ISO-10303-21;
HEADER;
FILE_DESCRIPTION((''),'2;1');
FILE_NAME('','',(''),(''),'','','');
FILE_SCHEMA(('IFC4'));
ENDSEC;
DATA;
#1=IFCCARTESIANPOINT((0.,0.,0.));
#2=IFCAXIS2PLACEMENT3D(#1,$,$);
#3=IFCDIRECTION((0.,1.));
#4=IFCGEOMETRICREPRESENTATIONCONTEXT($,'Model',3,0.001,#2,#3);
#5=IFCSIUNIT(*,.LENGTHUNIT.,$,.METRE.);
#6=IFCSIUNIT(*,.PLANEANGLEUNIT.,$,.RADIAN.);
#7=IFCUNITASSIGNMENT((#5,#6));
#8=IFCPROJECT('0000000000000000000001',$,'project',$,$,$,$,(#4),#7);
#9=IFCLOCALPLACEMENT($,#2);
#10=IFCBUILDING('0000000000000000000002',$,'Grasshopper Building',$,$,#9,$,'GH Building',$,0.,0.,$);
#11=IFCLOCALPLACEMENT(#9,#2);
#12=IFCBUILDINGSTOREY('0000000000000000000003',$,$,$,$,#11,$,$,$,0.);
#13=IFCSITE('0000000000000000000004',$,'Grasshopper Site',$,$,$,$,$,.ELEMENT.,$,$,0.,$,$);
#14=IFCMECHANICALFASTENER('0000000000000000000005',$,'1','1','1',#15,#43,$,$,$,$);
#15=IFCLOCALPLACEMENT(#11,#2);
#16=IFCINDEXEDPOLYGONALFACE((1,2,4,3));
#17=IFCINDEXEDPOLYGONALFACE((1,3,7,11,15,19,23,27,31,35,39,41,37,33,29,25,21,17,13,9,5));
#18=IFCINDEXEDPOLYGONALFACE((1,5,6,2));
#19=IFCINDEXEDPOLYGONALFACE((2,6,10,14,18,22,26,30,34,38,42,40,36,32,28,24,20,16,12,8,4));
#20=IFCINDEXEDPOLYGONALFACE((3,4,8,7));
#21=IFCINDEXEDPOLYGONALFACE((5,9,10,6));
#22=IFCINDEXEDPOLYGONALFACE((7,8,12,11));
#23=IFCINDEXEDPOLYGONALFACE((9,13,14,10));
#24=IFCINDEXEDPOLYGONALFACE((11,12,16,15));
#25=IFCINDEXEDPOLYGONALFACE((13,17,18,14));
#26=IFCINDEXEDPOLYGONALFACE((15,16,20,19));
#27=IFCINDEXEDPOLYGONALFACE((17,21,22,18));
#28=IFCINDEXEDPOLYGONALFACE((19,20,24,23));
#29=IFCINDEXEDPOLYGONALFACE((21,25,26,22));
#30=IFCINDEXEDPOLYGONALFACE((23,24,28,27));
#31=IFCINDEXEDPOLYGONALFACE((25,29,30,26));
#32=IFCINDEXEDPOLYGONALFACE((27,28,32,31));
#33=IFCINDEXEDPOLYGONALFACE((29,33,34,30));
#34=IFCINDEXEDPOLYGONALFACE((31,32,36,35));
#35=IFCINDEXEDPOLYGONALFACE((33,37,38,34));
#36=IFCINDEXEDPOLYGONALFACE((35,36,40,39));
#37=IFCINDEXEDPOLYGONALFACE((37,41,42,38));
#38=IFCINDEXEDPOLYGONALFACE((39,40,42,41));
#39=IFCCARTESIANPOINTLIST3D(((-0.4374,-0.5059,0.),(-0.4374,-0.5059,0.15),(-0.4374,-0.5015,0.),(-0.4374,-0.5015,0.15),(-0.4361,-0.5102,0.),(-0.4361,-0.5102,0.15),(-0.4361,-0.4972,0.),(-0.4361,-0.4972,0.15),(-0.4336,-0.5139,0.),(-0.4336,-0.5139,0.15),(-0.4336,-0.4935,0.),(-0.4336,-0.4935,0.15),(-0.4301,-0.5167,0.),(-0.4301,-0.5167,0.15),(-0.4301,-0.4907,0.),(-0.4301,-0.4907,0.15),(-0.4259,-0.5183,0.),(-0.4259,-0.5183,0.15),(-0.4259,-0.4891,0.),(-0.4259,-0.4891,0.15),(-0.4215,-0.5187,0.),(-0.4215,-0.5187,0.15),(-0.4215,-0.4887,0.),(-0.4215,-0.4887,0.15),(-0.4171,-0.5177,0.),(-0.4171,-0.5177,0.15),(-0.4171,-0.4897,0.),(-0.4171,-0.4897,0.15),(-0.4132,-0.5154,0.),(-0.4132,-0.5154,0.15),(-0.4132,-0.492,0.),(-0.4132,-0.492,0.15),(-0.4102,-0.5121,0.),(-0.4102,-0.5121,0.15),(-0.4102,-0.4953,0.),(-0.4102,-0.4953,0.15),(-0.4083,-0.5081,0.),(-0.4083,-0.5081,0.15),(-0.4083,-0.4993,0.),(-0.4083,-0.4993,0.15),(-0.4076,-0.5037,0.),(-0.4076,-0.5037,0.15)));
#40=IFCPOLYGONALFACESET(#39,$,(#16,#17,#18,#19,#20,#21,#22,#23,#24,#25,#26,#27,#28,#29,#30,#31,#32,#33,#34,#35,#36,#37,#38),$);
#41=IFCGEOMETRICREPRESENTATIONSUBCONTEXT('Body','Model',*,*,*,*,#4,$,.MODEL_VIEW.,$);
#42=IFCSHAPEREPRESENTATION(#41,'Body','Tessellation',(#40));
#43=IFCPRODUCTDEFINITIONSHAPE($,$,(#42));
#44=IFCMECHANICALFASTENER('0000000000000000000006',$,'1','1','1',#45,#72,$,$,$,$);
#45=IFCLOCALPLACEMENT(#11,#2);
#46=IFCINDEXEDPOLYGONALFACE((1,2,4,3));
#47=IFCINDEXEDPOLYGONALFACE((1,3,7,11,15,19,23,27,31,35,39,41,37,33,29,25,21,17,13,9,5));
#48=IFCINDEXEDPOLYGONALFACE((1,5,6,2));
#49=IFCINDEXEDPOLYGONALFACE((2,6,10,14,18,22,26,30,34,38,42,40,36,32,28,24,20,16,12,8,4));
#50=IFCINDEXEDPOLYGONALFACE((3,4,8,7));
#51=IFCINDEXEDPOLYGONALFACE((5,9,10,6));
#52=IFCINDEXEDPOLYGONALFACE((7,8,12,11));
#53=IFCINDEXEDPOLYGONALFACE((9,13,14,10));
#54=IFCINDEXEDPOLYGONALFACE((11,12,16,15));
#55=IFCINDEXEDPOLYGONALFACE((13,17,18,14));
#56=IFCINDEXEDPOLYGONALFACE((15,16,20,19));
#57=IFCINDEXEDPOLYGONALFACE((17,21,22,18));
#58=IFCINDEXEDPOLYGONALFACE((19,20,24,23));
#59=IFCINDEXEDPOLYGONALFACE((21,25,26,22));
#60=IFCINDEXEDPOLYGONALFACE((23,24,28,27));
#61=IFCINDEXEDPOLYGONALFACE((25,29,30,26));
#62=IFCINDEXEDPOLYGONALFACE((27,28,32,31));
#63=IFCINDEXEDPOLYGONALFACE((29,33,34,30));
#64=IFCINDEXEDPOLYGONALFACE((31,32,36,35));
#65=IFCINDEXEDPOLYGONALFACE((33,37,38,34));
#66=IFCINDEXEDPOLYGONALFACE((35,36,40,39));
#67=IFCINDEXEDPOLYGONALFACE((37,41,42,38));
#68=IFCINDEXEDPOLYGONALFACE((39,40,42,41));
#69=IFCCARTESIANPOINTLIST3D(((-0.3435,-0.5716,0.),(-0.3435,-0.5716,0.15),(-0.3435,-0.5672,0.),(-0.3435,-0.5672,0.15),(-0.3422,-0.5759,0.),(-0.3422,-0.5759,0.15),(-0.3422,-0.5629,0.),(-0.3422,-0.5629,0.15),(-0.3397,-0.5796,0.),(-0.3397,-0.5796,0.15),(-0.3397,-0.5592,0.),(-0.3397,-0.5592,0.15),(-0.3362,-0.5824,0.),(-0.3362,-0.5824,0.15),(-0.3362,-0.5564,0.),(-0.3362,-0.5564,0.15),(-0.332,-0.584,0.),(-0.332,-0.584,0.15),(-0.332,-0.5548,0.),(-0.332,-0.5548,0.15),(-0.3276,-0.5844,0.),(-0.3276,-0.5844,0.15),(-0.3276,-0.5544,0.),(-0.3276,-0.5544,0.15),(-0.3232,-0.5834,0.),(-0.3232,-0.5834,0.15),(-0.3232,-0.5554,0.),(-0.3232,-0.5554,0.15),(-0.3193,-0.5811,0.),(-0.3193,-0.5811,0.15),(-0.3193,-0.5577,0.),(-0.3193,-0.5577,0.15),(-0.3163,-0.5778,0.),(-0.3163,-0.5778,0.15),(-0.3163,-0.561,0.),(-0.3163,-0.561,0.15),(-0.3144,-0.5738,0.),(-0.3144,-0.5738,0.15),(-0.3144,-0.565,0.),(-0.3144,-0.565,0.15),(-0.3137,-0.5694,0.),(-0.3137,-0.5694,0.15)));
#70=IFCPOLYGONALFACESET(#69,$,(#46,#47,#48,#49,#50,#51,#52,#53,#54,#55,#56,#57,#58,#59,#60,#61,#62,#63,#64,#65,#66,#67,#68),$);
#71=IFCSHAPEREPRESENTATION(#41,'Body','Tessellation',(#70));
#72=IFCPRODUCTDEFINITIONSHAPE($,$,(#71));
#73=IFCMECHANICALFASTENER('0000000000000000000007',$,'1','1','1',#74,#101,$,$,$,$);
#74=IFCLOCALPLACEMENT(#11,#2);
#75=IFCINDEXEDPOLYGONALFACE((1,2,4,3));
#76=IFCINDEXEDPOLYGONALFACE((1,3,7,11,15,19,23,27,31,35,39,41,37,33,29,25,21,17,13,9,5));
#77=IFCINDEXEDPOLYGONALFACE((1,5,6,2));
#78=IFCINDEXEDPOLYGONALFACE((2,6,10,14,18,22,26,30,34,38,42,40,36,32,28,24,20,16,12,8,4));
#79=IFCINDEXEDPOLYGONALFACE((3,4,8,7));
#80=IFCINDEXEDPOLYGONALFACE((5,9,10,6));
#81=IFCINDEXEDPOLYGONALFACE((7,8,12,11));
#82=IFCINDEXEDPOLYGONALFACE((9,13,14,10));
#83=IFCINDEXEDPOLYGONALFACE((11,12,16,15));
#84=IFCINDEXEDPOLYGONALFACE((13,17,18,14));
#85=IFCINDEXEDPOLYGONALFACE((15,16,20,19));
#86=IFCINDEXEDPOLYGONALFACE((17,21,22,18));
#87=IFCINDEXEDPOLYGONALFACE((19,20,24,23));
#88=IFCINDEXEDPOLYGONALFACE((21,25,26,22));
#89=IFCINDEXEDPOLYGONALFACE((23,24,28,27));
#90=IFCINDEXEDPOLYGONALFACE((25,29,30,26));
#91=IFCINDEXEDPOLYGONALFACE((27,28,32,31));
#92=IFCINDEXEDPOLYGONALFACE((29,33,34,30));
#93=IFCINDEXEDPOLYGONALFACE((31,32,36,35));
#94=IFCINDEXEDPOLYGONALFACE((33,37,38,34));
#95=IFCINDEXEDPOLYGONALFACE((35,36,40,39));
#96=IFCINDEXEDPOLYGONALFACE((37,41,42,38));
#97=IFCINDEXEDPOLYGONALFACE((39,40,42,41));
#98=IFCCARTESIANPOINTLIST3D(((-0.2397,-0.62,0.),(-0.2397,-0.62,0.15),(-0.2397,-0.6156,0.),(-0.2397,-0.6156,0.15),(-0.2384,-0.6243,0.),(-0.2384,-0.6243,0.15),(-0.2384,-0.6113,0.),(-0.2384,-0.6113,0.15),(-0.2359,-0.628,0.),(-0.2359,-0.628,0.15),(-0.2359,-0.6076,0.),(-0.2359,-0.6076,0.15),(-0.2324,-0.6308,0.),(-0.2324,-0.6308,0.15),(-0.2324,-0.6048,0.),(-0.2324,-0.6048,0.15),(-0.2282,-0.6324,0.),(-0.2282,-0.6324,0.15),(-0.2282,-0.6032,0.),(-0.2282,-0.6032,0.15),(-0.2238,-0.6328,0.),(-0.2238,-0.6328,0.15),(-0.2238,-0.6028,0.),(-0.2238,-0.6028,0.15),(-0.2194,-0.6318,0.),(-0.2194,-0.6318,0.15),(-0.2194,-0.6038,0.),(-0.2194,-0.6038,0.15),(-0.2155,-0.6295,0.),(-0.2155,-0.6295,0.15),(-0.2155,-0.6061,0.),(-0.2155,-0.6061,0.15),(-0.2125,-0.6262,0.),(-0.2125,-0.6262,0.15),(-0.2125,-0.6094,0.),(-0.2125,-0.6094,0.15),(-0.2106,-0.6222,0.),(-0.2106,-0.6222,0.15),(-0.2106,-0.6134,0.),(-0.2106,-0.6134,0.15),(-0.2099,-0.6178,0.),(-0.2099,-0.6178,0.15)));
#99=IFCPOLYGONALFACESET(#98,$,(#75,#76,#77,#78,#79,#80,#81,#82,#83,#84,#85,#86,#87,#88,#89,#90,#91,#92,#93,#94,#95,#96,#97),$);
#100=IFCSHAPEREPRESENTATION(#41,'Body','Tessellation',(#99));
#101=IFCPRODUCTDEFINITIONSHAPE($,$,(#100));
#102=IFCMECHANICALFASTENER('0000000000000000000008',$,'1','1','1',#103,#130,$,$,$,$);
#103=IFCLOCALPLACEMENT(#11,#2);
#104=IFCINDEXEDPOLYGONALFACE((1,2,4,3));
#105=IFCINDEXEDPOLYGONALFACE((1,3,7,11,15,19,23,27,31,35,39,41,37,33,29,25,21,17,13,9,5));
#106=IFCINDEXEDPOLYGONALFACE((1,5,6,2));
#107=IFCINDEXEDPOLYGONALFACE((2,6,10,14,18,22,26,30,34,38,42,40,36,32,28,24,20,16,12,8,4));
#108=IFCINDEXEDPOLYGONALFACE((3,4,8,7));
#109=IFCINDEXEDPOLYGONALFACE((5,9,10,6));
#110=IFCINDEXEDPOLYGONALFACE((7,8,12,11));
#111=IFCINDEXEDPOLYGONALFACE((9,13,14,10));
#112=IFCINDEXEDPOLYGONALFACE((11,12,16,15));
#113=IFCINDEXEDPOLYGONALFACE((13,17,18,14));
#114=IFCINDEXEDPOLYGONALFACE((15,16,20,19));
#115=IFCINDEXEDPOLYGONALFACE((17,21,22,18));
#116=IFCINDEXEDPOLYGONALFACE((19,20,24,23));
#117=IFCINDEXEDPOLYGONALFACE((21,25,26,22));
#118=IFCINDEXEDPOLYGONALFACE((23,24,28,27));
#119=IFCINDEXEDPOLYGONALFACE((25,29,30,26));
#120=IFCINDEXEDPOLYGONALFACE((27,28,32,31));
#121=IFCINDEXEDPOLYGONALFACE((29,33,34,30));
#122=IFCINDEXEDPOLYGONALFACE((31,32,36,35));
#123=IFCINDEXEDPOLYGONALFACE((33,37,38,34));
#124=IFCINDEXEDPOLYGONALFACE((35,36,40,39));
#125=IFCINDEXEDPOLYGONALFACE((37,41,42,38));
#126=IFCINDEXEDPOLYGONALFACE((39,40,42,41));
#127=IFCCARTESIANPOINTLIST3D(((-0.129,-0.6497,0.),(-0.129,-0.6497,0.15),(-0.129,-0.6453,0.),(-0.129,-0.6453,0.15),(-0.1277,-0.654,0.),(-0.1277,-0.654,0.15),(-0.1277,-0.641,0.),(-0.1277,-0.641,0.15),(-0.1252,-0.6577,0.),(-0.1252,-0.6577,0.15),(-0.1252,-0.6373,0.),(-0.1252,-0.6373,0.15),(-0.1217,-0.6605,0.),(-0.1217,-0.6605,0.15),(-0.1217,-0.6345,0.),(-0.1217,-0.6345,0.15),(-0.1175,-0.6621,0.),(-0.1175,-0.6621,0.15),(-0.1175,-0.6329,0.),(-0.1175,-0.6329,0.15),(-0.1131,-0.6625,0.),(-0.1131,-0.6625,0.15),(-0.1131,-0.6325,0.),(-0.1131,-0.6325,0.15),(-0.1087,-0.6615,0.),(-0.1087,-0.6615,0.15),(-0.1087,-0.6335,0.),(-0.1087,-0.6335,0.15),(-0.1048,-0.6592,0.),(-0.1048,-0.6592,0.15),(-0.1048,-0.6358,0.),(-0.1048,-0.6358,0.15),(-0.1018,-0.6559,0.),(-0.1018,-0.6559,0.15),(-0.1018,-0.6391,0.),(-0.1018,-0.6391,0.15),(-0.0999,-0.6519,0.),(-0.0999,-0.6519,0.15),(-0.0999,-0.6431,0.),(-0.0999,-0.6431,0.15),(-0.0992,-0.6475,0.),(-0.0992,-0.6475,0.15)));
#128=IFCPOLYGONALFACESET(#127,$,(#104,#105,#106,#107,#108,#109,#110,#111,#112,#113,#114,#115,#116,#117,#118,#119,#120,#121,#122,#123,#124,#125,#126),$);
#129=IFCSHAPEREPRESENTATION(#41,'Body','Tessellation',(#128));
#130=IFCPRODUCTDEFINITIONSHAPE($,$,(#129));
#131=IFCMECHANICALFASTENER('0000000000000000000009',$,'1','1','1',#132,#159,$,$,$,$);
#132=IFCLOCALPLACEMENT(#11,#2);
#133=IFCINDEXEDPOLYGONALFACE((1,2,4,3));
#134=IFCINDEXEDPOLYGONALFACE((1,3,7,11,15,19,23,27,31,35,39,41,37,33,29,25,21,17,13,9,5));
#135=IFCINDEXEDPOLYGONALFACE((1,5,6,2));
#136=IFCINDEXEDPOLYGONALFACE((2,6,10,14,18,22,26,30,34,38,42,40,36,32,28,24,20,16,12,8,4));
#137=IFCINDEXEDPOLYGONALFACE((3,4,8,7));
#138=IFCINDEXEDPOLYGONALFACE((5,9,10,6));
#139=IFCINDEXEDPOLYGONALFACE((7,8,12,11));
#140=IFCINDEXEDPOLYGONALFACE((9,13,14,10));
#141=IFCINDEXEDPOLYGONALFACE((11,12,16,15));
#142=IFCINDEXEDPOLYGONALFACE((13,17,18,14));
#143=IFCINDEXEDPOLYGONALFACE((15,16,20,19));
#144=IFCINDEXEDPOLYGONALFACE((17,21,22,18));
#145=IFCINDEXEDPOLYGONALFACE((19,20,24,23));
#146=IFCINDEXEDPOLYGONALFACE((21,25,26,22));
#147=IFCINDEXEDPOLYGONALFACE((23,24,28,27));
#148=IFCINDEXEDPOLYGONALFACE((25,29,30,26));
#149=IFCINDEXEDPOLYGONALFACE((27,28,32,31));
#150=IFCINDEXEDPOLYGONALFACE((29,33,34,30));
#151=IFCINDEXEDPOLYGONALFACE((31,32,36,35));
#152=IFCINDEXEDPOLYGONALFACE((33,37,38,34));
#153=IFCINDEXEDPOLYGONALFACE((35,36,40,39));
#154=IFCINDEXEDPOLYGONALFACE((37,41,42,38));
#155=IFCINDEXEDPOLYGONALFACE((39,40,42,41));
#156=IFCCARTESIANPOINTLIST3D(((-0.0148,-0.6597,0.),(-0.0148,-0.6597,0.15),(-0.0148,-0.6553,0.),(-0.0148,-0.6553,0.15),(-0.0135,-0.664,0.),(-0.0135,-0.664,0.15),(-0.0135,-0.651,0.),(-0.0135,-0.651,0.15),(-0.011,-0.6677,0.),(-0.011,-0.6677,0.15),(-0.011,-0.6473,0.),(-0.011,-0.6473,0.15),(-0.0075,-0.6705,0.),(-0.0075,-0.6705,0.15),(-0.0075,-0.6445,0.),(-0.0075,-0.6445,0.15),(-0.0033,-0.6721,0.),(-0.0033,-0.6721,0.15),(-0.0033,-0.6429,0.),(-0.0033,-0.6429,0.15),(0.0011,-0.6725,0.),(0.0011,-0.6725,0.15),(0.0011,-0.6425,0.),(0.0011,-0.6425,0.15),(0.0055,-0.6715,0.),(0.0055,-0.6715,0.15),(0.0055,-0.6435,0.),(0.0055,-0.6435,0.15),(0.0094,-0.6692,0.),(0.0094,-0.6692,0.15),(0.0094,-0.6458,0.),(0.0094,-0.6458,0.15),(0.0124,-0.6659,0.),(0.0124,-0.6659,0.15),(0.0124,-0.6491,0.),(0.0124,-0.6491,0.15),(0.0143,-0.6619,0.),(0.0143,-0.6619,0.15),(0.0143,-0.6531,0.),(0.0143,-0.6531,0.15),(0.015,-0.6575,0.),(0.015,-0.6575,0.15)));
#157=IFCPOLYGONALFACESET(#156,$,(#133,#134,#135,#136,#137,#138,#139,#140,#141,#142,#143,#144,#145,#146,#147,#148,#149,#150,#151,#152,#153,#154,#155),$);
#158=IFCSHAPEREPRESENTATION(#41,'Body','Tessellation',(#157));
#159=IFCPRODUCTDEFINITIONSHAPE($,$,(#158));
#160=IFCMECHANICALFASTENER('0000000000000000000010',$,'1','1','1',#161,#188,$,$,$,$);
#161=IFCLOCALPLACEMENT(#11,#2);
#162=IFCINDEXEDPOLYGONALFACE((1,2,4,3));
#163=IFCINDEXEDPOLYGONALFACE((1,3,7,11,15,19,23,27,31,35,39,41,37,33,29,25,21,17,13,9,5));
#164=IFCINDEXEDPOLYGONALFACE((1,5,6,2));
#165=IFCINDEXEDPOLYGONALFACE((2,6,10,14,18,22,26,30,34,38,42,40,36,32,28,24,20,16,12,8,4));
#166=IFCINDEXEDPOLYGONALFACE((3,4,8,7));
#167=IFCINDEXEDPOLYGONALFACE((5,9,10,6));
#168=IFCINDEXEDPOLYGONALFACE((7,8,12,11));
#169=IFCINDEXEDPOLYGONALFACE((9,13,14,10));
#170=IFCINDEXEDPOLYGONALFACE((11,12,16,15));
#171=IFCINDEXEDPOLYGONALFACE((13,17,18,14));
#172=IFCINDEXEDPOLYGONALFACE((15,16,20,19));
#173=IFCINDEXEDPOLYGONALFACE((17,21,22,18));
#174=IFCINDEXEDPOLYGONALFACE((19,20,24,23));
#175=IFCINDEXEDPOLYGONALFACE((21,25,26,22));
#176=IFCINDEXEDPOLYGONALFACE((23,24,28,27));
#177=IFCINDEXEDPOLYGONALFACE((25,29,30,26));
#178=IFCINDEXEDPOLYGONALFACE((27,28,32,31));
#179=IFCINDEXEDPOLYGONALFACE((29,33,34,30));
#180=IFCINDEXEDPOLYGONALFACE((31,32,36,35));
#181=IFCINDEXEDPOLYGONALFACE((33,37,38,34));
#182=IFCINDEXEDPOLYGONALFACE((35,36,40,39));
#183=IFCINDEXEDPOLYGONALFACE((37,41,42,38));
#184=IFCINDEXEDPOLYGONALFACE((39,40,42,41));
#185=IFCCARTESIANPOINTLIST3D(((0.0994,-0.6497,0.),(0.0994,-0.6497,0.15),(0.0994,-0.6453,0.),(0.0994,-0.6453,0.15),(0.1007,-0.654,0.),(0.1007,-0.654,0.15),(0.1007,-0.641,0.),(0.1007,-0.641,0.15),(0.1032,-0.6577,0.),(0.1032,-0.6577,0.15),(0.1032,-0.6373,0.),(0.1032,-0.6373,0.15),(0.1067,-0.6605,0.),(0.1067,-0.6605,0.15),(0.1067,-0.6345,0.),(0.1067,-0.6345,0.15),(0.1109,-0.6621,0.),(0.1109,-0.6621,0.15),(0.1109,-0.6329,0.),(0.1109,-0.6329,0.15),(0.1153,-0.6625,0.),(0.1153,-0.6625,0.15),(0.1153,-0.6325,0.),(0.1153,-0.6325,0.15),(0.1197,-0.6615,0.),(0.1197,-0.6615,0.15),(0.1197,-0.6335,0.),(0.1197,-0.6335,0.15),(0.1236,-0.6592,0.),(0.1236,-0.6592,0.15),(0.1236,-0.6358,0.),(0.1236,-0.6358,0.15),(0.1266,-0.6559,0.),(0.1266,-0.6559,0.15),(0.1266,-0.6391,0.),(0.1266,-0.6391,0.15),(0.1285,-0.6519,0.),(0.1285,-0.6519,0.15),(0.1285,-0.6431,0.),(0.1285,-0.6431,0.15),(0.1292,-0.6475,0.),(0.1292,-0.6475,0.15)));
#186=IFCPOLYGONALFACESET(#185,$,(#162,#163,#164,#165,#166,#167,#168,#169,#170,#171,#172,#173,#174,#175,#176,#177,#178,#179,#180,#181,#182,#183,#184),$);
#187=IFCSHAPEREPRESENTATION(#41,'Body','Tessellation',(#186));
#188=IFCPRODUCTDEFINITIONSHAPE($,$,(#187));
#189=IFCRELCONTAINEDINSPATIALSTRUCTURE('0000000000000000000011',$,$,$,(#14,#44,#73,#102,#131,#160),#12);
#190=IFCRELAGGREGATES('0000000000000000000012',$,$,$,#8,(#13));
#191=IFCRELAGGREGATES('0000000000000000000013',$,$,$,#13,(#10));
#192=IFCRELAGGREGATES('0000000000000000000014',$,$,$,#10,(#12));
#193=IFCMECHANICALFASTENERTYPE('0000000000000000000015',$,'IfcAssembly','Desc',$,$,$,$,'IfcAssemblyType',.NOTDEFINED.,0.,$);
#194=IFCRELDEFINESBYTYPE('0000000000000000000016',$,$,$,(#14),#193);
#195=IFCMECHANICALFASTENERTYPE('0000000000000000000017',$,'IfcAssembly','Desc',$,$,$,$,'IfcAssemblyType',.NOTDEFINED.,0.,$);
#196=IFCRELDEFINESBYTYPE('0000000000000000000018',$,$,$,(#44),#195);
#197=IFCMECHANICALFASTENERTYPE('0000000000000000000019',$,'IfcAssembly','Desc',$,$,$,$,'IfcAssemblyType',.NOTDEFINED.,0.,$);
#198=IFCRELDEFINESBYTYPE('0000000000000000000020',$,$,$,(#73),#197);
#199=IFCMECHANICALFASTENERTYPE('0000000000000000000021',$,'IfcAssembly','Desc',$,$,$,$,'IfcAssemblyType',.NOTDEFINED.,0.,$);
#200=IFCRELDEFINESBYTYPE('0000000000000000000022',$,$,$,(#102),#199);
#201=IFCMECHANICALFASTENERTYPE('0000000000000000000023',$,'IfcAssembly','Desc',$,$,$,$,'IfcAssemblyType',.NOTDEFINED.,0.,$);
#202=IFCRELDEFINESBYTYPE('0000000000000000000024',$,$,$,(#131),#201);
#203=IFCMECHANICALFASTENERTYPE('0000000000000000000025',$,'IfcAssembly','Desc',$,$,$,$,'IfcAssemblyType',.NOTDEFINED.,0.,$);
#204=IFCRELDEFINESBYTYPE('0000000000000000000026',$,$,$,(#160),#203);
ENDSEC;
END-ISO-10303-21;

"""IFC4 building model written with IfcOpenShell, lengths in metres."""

from ifc_helpers import new_model, si_unit, direction, frame, origin, place, context, subcontext, project, spatial, circle, extrude, source, transform, mapped, type_object, type_shapes, element, save


model = new_model("IFC4")

# Units and contexts
model_context = context("Model", 3, precision=0.001, world=origin(), true_north=direction((0.0, 1.0)))
body_context = subcontext(model_context, "Body", "Model", "MODEL_VIEW")
ifc_project = project(units=[si_unit("LENGTHUNIT", "METRE"), si_unit("PLANEANGLEUNIT", "RADIAN")], contexts=[model_context])

# Site, building, storey
site = spatial("IfcSite", under=ifc_project, Name="Grasshopper Site", CompositionType="ELEMENT", RefElevation=0.0)
building_placement = place(None, origin())
building = spatial("IfcBuilding", under=site, at=building_placement, Name="Grasshopper Building", LongName="GH Building", ElevationOfRefHeight=0.0, ElevationOfTerrain=0.0)
storey_placement = place(building_placement, origin())
storey = spatial("IfcBuildingStorey", under=building, at=storey_placement, Elevation=0.0)

# Mechanical fasteners
mechanical_fastener_type_1 = type_object("IfcMechanicalFastenerType", Name="IfcAssembly", Description="Desc", ElementType="IfcAssemblyType", NominalDiameter=0.0)
shared_shape_1 = source(origin(), body_context, "Body", "SweptSolid", [
    extrude(circle(Radius=0.015), frame((-0.4226, -0.5037, 0.0)), (0.0, 0.0, 1.0), 0.15),
])
type_shapes(mechanical_fastener_type_1, [shared_shape_1])
mechanical_fastener_1_placement = place(storey_placement, origin())
element("IfcMechanicalFastener", 1, at=mechanical_fastener_1_placement, inside=storey, type_object=mechanical_fastener_type_1, Name="1", Description="1", ObjectType="1", context=body_context, shape_type="MappedRepresentation", body=[
    mapped(shared_shape_1, transform((0.0, 0.0, 0.0), scale=1.0)),
])
mechanical_fastener_type_2 = type_object("IfcMechanicalFastenerType", Name="IfcAssembly", Description="Desc", ElementType="IfcAssemblyType", NominalDiameter=0.0)
shared_shape_2 = source(origin(), body_context, "Body", "SweptSolid", [
    extrude(circle(Radius=0.015), frame((-0.3287, -0.5694, 0.0)), (0.0, 0.0, 1.0), 0.15),
])
type_shapes(mechanical_fastener_type_2, [shared_shape_2])
mechanical_fastener_2_placement = place(storey_placement, origin())
element("IfcMechanicalFastener", 2, at=mechanical_fastener_2_placement, inside=storey, type_object=mechanical_fastener_type_2, Name="1", Description="1", ObjectType="1", context=body_context, shape_type="MappedRepresentation", body=[
    mapped(shared_shape_2, transform((0.0, 0.0, 0.0), scale=1.0)),
])
mechanical_fastener_type_3 = type_object("IfcMechanicalFastenerType", Name="IfcAssembly", Description="Desc", ElementType="IfcAssemblyType", NominalDiameter=0.0)
shared_shape_3 = source(origin(), body_context, "Body", "SweptSolid", [
    extrude(circle(Radius=0.015), frame((-0.2249, -0.6178, 0.0)), (0.0, 0.0, 1.0), 0.15),
])
type_shapes(mechanical_fastener_type_3, [shared_shape_3])
mechanical_fastener_3_placement = place(storey_placement, origin())
element("IfcMechanicalFastener", 3, at=mechanical_fastener_3_placement, inside=storey, type_object=mechanical_fastener_type_3, Name="1", Description="1", ObjectType="1", context=body_context, shape_type="MappedRepresentation", body=[
    mapped(shared_shape_3, transform((0.0, 0.0, 0.0), scale=1.0)),
])
mechanical_fastener_type_4 = type_object("IfcMechanicalFastenerType", Name="IfcAssembly", Description="Desc", ElementType="IfcAssemblyType", NominalDiameter=0.0)
shared_shape_4 = source(origin(), body_context, "Body", "SweptSolid", [
    extrude(circle(Radius=0.015), frame((-0.1142, -0.6475, 0.0)), (0.0, 0.0, 1.0), 0.15),
])
type_shapes(mechanical_fastener_type_4, [shared_shape_4])
mechanical_fastener_4_placement = place(storey_placement, origin())
element("IfcMechanicalFastener", 4, at=mechanical_fastener_4_placement, inside=storey, type_object=mechanical_fastener_type_4, Name="1", Description="1", ObjectType="1", context=body_context, shape_type="MappedRepresentation", body=[
    mapped(shared_shape_4, transform((0.0, 0.0, 0.0), scale=1.0)),
])
mechanical_fastener_type_5 = type_object("IfcMechanicalFastenerType", Name="IfcAssembly", Description="Desc", ElementType="IfcAssemblyType", NominalDiameter=0.0)
shared_shape_5 = source(origin(), body_context, "Body", "SweptSolid", [
    extrude(circle(Radius=0.015), frame((0.0, -0.6575, 0.0)), (0.0, 0.0, 1.0), 0.15),
])
type_shapes(mechanical_fastener_type_5, [shared_shape_5])
mechanical_fastener_5_placement = place(storey_placement, origin())
element("IfcMechanicalFastener", 5, at=mechanical_fastener_5_placement, inside=storey, type_object=mechanical_fastener_type_5, Name="1", Description="1", ObjectType="1", context=body_context, shape_type="MappedRepresentation", body=[
    mapped(shared_shape_5, transform((0.0, 0.0, 0.0), scale=1.0)),
])
mechanical_fastener_type_6 = type_object("IfcMechanicalFastenerType", Name="IfcAssembly", Description="Desc", ElementType="IfcAssemblyType", NominalDiameter=0.0)
shared_shape_6 = source(origin(), body_context, "Body", "SweptSolid", [
    extrude(circle(Radius=0.015), frame((0.1142, -0.6475, 0.0)), (0.0, 0.0, 1.0), 0.15),
])
type_shapes(mechanical_fastener_type_6, [shared_shape_6])
mechanical_fastener_6_placement = place(storey_placement, origin())
element("IfcMechanicalFastener", 6, at=mechanical_fastener_6_placement, inside=storey, type_object=mechanical_fastener_type_6, Name="1", Description="1", ObjectType="1", context=body_context, shape_type="MappedRepresentation", body=[
    mapped(shared_shape_6, transform((0.0, 0.0, 0.0), scale=1.0)),
])

save(model, "model.ifc")
